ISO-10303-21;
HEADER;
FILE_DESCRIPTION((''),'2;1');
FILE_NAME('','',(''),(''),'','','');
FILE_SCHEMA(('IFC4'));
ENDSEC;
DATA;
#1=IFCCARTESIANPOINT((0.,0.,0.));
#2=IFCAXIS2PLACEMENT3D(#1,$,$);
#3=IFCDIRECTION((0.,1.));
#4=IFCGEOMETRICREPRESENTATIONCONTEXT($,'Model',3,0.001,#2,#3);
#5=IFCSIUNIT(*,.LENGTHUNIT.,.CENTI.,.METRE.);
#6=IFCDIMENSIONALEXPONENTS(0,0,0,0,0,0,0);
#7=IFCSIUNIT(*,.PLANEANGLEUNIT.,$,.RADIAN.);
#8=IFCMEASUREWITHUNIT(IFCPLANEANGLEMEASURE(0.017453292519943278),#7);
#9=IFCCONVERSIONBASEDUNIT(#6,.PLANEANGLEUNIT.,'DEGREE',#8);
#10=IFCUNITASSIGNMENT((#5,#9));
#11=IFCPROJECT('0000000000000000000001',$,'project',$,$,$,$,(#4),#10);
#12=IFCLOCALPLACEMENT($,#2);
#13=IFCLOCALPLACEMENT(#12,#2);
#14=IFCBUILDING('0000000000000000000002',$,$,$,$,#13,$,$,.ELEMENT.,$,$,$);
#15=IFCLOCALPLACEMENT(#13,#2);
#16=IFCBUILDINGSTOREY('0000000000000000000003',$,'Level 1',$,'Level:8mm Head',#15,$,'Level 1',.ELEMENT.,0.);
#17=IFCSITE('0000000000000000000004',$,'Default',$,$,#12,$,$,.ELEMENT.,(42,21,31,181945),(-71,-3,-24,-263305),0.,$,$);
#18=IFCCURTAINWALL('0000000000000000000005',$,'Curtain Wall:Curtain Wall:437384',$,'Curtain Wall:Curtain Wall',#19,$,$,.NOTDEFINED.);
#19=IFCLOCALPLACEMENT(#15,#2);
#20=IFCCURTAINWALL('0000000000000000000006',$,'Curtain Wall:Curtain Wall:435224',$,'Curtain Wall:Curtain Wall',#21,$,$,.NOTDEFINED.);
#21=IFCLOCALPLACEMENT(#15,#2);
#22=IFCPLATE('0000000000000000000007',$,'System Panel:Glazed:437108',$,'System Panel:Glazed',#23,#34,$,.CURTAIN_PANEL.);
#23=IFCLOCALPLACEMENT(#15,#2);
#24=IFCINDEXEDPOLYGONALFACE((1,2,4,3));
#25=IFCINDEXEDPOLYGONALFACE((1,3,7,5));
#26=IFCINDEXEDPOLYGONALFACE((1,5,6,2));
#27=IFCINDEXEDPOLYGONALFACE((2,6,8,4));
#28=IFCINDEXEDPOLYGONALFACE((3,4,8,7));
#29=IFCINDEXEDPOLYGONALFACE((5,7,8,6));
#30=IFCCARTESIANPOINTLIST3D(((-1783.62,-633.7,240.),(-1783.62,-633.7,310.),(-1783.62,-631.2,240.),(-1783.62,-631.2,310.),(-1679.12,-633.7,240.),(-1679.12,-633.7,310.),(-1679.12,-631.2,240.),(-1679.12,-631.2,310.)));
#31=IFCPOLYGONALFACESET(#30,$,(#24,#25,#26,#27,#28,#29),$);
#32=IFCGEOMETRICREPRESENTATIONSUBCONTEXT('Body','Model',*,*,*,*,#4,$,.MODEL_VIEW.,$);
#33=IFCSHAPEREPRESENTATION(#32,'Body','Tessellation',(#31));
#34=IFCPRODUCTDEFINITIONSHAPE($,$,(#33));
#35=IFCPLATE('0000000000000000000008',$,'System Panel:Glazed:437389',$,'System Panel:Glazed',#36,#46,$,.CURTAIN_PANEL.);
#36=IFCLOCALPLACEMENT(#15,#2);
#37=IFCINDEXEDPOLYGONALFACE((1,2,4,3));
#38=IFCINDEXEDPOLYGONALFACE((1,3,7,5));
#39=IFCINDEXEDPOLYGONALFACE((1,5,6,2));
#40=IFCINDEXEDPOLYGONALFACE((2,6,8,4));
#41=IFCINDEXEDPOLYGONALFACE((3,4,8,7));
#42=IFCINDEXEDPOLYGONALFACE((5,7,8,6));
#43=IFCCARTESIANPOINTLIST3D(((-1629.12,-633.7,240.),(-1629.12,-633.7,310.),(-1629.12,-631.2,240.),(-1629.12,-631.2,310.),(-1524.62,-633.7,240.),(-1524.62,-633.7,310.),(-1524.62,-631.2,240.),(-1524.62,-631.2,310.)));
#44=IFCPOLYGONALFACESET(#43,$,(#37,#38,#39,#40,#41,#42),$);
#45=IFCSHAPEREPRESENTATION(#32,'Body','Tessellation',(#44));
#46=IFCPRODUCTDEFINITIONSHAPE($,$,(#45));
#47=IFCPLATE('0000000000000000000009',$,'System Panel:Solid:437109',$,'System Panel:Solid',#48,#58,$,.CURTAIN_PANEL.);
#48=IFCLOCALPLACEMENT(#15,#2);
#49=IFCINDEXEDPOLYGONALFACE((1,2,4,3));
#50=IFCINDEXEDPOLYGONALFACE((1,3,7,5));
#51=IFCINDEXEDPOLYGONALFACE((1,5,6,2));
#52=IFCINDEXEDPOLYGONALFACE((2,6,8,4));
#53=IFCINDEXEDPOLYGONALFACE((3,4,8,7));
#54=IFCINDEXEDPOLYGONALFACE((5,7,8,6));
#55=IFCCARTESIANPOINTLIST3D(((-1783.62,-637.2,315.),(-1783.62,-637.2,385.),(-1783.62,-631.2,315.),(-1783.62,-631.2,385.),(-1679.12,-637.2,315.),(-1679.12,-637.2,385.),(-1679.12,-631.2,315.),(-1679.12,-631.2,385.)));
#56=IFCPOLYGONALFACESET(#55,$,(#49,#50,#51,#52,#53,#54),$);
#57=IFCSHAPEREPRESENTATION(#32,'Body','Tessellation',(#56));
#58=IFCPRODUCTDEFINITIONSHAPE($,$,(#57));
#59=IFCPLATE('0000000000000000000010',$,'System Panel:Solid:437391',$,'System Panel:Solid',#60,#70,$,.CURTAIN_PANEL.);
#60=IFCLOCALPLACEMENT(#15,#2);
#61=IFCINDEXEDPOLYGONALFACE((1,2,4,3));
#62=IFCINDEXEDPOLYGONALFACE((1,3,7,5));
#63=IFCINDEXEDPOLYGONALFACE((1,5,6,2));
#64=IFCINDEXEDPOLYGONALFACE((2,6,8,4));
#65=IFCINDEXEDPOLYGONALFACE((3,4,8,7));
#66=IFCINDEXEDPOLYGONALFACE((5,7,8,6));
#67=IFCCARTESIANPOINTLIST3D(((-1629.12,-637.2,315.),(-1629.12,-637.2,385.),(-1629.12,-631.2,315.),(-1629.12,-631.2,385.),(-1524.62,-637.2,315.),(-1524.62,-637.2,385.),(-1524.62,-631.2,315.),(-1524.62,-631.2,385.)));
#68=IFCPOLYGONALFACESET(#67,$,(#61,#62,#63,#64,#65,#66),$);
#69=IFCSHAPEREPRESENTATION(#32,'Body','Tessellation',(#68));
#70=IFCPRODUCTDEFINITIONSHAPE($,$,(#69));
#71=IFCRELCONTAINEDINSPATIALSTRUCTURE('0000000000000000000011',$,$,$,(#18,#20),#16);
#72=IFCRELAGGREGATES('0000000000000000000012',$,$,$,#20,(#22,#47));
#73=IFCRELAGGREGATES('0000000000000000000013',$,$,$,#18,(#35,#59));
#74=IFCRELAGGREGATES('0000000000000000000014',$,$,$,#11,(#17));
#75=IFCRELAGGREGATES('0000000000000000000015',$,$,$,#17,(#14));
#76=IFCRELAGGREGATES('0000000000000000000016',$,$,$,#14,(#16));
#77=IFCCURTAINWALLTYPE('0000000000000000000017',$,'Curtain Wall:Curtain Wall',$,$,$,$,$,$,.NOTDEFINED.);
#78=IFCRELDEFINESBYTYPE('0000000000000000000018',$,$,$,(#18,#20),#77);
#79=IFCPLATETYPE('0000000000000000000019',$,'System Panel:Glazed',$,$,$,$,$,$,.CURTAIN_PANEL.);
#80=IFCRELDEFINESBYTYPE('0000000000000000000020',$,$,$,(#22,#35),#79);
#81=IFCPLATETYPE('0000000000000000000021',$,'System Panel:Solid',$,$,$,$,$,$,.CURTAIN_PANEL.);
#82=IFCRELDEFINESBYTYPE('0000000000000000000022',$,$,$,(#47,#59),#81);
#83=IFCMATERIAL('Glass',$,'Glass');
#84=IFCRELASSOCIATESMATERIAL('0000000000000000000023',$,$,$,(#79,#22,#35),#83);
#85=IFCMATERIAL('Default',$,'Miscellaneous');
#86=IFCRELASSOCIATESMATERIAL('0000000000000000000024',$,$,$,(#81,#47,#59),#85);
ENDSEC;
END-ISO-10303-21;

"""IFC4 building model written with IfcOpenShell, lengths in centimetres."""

from ifc_helpers import new_model, entity, si_unit, converted_unit, direction, frame, origin, place, context, subcontext, project, spatial, indexed_curve, outline, extrude, source, transform, mapped, material, type_object, type_shapes, element, aggregate, save


model = new_model("IFC4")

# Units and contexts
model_context = context("Model", 3, precision=0.001, world=origin(), true_north=direction((0.0, 1.0)))
body_context = subcontext(model_context, "Body", "Model", "MODEL_VIEW")
ifc_project = project(units=[si_unit("LENGTHUNIT", "METRE", prefix="CENTI"), converted_unit("PLANEANGLEUNIT", "DEGREE", entity("IfcPlaneAngleMeasure", 0.017453292519943278), si_unit("PLANEANGLEUNIT", "RADIAN"), dimensions=[0, 0, 0, 0, 0, 0, 0])], contexts=[model_context])

# Site, building, storey
site_placement = place(None, origin())
site = spatial("IfcSite", under=ifc_project, at=site_placement, Name="Default", CompositionType="ELEMENT", RefLatitude=(42, 21, 31, 181945), RefLongitude=(-71, -3, -24, -263305), RefElevation=0.0)
building_placement = place(site_placement, origin())
building = spatial("IfcBuilding", under=site, at=building_placement, CompositionType="ELEMENT")
storey_placement = place(building_placement, origin())
storey = spatial("IfcBuildingStorey", under=building, at=storey_placement, Name="Level 1", ObjectType="Level:8mm Head", LongName="Level 1", CompositionType="ELEMENT", Elevation=0.0)

# Curtain walls
curtain_wall_type = type_object("IfcCurtainWallType", Name="Curtain Wall:Curtain Wall", PredefinedType="NOTDEFINED")
curtain_wall_1_placement = place(storey_placement, origin())
curtain_wall_1 = element("IfcCurtainWall", 1, at=curtain_wall_1_placement, inside=storey, type_object=curtain_wall_type, Name="Curtain Wall:Curtain Wall:437384", ObjectType="Curtain Wall:Curtain Wall", PredefinedType="NOTDEFINED")
curtain_wall_2_placement = place(storey_placement, origin())
curtain_wall_2 = element("IfcCurtainWall", 2, at=curtain_wall_2_placement, inside=storey, type_object=curtain_wall_type, Name="Curtain Wall:Curtain Wall:435224", ObjectType="Curtain Wall:Curtain Wall", PredefinedType="NOTDEFINED")

# Plates
ifc_material_1 = material(Name="Glass", Category="Glass")
plate_type_1 = type_object("IfcPlateType", Name="System Panel:Glazed", PredefinedType="CURTAIN_PANEL", material=ifc_material_1)
shared_shape_1 = source(origin(), body_context, "Body", "SweptSolid", [
    extrude(outline(indexed_curve([(-1.25, -52.25), (1.25, -52.25), (1.25, 52.25), (-1.25, 52.25), (-1.25, -52.25)], self_intersect=False)), frame((0.0, 3.7, 0.0), z_axis=(0.0, 0.0, 1.0), x_axis=(0.0, 1.0, 0.0)), (0.0, 0.0, 1.0), 70.0),
])
type_shapes(plate_type_1, [shared_shape_1])
plate_1_placement = place(curtain_wall_2_placement, frame((-1731.37, -636.15, 240.0)))
plate_1 = element("IfcPlate", 3, at=plate_1_placement, type_object=plate_type_1, material=ifc_material_1, Name="System Panel:Glazed:437108", ObjectType="System Panel:Glazed", PredefinedType="CURTAIN_PANEL", context=body_context, shape_type="MappedRepresentation", body=[
    mapped(shared_shape_1, transform((0.0, 0.0, 0.0), scale=1.0)),
])
plate_2_placement = place(curtain_wall_1_placement, frame((-1576.87, -636.15, 240.0)))
plate_2 = element("IfcPlate", 4, at=plate_2_placement, type_object=plate_type_1, material=ifc_material_1, Name="System Panel:Glazed:437389", ObjectType="System Panel:Glazed", PredefinedType="CURTAIN_PANEL", context=body_context, shape_type="MappedRepresentation", body=[
    mapped(shared_shape_1, transform((0.0, 0.0, 0.0), scale=1.0)),
])
ifc_material_2 = material(Name="Default", Category="Miscellaneous")
plate_type_2 = type_object("IfcPlateType", Name="System Panel:Solid", PredefinedType="CURTAIN_PANEL", material=ifc_material_2)
shared_shape_2 = source(origin(), body_context, "Body", "SweptSolid", [
    extrude(outline(indexed_curve([(-3.0, -52.25), (3.0, -52.25), (3.0, 52.25), (-3.0, 52.25), (-3.0, -52.25)], self_intersect=False)), frame((0.0, 1.95, 0.0), z_axis=(0.0, 0.0, 1.0), x_axis=(0.0, 1.0, 0.0)), (0.0, 0.0, 1.0), 70.0),
])
type_shapes(plate_type_2, [shared_shape_2])
plate_3_placement = place(curtain_wall_2_placement, frame((-1731.37, -636.15, 315.0)))
plate_3 = element("IfcPlate", 5, at=plate_3_placement, type_object=plate_type_2, material=ifc_material_2, Name="System Panel:Solid:437109", ObjectType="System Panel:Solid", PredefinedType="CURTAIN_PANEL", context=body_context, shape_type="MappedRepresentation", body=[
    mapped(shared_shape_2, transform((0.0, 0.0, 0.0), scale=1.0)),
])
aggregate(curtain_wall_2, [plate_1, plate_3])
plate_4_placement = place(curtain_wall_1_placement, frame((-1576.87, -636.15, 315.0)))
plate_4 = element("IfcPlate", 6, at=plate_4_placement, type_object=plate_type_2, material=ifc_material_2, Name="System Panel:Solid:437391", ObjectType="System Panel:Solid", PredefinedType="CURTAIN_PANEL", context=body_context, shape_type="MappedRepresentation", body=[
    mapped(shared_shape_2, transform((0.0, 0.0, 0.0), scale=1.0)),
])
aggregate(curtain_wall_1, [plate_2, plate_4])

save(model, "model.ifc")
